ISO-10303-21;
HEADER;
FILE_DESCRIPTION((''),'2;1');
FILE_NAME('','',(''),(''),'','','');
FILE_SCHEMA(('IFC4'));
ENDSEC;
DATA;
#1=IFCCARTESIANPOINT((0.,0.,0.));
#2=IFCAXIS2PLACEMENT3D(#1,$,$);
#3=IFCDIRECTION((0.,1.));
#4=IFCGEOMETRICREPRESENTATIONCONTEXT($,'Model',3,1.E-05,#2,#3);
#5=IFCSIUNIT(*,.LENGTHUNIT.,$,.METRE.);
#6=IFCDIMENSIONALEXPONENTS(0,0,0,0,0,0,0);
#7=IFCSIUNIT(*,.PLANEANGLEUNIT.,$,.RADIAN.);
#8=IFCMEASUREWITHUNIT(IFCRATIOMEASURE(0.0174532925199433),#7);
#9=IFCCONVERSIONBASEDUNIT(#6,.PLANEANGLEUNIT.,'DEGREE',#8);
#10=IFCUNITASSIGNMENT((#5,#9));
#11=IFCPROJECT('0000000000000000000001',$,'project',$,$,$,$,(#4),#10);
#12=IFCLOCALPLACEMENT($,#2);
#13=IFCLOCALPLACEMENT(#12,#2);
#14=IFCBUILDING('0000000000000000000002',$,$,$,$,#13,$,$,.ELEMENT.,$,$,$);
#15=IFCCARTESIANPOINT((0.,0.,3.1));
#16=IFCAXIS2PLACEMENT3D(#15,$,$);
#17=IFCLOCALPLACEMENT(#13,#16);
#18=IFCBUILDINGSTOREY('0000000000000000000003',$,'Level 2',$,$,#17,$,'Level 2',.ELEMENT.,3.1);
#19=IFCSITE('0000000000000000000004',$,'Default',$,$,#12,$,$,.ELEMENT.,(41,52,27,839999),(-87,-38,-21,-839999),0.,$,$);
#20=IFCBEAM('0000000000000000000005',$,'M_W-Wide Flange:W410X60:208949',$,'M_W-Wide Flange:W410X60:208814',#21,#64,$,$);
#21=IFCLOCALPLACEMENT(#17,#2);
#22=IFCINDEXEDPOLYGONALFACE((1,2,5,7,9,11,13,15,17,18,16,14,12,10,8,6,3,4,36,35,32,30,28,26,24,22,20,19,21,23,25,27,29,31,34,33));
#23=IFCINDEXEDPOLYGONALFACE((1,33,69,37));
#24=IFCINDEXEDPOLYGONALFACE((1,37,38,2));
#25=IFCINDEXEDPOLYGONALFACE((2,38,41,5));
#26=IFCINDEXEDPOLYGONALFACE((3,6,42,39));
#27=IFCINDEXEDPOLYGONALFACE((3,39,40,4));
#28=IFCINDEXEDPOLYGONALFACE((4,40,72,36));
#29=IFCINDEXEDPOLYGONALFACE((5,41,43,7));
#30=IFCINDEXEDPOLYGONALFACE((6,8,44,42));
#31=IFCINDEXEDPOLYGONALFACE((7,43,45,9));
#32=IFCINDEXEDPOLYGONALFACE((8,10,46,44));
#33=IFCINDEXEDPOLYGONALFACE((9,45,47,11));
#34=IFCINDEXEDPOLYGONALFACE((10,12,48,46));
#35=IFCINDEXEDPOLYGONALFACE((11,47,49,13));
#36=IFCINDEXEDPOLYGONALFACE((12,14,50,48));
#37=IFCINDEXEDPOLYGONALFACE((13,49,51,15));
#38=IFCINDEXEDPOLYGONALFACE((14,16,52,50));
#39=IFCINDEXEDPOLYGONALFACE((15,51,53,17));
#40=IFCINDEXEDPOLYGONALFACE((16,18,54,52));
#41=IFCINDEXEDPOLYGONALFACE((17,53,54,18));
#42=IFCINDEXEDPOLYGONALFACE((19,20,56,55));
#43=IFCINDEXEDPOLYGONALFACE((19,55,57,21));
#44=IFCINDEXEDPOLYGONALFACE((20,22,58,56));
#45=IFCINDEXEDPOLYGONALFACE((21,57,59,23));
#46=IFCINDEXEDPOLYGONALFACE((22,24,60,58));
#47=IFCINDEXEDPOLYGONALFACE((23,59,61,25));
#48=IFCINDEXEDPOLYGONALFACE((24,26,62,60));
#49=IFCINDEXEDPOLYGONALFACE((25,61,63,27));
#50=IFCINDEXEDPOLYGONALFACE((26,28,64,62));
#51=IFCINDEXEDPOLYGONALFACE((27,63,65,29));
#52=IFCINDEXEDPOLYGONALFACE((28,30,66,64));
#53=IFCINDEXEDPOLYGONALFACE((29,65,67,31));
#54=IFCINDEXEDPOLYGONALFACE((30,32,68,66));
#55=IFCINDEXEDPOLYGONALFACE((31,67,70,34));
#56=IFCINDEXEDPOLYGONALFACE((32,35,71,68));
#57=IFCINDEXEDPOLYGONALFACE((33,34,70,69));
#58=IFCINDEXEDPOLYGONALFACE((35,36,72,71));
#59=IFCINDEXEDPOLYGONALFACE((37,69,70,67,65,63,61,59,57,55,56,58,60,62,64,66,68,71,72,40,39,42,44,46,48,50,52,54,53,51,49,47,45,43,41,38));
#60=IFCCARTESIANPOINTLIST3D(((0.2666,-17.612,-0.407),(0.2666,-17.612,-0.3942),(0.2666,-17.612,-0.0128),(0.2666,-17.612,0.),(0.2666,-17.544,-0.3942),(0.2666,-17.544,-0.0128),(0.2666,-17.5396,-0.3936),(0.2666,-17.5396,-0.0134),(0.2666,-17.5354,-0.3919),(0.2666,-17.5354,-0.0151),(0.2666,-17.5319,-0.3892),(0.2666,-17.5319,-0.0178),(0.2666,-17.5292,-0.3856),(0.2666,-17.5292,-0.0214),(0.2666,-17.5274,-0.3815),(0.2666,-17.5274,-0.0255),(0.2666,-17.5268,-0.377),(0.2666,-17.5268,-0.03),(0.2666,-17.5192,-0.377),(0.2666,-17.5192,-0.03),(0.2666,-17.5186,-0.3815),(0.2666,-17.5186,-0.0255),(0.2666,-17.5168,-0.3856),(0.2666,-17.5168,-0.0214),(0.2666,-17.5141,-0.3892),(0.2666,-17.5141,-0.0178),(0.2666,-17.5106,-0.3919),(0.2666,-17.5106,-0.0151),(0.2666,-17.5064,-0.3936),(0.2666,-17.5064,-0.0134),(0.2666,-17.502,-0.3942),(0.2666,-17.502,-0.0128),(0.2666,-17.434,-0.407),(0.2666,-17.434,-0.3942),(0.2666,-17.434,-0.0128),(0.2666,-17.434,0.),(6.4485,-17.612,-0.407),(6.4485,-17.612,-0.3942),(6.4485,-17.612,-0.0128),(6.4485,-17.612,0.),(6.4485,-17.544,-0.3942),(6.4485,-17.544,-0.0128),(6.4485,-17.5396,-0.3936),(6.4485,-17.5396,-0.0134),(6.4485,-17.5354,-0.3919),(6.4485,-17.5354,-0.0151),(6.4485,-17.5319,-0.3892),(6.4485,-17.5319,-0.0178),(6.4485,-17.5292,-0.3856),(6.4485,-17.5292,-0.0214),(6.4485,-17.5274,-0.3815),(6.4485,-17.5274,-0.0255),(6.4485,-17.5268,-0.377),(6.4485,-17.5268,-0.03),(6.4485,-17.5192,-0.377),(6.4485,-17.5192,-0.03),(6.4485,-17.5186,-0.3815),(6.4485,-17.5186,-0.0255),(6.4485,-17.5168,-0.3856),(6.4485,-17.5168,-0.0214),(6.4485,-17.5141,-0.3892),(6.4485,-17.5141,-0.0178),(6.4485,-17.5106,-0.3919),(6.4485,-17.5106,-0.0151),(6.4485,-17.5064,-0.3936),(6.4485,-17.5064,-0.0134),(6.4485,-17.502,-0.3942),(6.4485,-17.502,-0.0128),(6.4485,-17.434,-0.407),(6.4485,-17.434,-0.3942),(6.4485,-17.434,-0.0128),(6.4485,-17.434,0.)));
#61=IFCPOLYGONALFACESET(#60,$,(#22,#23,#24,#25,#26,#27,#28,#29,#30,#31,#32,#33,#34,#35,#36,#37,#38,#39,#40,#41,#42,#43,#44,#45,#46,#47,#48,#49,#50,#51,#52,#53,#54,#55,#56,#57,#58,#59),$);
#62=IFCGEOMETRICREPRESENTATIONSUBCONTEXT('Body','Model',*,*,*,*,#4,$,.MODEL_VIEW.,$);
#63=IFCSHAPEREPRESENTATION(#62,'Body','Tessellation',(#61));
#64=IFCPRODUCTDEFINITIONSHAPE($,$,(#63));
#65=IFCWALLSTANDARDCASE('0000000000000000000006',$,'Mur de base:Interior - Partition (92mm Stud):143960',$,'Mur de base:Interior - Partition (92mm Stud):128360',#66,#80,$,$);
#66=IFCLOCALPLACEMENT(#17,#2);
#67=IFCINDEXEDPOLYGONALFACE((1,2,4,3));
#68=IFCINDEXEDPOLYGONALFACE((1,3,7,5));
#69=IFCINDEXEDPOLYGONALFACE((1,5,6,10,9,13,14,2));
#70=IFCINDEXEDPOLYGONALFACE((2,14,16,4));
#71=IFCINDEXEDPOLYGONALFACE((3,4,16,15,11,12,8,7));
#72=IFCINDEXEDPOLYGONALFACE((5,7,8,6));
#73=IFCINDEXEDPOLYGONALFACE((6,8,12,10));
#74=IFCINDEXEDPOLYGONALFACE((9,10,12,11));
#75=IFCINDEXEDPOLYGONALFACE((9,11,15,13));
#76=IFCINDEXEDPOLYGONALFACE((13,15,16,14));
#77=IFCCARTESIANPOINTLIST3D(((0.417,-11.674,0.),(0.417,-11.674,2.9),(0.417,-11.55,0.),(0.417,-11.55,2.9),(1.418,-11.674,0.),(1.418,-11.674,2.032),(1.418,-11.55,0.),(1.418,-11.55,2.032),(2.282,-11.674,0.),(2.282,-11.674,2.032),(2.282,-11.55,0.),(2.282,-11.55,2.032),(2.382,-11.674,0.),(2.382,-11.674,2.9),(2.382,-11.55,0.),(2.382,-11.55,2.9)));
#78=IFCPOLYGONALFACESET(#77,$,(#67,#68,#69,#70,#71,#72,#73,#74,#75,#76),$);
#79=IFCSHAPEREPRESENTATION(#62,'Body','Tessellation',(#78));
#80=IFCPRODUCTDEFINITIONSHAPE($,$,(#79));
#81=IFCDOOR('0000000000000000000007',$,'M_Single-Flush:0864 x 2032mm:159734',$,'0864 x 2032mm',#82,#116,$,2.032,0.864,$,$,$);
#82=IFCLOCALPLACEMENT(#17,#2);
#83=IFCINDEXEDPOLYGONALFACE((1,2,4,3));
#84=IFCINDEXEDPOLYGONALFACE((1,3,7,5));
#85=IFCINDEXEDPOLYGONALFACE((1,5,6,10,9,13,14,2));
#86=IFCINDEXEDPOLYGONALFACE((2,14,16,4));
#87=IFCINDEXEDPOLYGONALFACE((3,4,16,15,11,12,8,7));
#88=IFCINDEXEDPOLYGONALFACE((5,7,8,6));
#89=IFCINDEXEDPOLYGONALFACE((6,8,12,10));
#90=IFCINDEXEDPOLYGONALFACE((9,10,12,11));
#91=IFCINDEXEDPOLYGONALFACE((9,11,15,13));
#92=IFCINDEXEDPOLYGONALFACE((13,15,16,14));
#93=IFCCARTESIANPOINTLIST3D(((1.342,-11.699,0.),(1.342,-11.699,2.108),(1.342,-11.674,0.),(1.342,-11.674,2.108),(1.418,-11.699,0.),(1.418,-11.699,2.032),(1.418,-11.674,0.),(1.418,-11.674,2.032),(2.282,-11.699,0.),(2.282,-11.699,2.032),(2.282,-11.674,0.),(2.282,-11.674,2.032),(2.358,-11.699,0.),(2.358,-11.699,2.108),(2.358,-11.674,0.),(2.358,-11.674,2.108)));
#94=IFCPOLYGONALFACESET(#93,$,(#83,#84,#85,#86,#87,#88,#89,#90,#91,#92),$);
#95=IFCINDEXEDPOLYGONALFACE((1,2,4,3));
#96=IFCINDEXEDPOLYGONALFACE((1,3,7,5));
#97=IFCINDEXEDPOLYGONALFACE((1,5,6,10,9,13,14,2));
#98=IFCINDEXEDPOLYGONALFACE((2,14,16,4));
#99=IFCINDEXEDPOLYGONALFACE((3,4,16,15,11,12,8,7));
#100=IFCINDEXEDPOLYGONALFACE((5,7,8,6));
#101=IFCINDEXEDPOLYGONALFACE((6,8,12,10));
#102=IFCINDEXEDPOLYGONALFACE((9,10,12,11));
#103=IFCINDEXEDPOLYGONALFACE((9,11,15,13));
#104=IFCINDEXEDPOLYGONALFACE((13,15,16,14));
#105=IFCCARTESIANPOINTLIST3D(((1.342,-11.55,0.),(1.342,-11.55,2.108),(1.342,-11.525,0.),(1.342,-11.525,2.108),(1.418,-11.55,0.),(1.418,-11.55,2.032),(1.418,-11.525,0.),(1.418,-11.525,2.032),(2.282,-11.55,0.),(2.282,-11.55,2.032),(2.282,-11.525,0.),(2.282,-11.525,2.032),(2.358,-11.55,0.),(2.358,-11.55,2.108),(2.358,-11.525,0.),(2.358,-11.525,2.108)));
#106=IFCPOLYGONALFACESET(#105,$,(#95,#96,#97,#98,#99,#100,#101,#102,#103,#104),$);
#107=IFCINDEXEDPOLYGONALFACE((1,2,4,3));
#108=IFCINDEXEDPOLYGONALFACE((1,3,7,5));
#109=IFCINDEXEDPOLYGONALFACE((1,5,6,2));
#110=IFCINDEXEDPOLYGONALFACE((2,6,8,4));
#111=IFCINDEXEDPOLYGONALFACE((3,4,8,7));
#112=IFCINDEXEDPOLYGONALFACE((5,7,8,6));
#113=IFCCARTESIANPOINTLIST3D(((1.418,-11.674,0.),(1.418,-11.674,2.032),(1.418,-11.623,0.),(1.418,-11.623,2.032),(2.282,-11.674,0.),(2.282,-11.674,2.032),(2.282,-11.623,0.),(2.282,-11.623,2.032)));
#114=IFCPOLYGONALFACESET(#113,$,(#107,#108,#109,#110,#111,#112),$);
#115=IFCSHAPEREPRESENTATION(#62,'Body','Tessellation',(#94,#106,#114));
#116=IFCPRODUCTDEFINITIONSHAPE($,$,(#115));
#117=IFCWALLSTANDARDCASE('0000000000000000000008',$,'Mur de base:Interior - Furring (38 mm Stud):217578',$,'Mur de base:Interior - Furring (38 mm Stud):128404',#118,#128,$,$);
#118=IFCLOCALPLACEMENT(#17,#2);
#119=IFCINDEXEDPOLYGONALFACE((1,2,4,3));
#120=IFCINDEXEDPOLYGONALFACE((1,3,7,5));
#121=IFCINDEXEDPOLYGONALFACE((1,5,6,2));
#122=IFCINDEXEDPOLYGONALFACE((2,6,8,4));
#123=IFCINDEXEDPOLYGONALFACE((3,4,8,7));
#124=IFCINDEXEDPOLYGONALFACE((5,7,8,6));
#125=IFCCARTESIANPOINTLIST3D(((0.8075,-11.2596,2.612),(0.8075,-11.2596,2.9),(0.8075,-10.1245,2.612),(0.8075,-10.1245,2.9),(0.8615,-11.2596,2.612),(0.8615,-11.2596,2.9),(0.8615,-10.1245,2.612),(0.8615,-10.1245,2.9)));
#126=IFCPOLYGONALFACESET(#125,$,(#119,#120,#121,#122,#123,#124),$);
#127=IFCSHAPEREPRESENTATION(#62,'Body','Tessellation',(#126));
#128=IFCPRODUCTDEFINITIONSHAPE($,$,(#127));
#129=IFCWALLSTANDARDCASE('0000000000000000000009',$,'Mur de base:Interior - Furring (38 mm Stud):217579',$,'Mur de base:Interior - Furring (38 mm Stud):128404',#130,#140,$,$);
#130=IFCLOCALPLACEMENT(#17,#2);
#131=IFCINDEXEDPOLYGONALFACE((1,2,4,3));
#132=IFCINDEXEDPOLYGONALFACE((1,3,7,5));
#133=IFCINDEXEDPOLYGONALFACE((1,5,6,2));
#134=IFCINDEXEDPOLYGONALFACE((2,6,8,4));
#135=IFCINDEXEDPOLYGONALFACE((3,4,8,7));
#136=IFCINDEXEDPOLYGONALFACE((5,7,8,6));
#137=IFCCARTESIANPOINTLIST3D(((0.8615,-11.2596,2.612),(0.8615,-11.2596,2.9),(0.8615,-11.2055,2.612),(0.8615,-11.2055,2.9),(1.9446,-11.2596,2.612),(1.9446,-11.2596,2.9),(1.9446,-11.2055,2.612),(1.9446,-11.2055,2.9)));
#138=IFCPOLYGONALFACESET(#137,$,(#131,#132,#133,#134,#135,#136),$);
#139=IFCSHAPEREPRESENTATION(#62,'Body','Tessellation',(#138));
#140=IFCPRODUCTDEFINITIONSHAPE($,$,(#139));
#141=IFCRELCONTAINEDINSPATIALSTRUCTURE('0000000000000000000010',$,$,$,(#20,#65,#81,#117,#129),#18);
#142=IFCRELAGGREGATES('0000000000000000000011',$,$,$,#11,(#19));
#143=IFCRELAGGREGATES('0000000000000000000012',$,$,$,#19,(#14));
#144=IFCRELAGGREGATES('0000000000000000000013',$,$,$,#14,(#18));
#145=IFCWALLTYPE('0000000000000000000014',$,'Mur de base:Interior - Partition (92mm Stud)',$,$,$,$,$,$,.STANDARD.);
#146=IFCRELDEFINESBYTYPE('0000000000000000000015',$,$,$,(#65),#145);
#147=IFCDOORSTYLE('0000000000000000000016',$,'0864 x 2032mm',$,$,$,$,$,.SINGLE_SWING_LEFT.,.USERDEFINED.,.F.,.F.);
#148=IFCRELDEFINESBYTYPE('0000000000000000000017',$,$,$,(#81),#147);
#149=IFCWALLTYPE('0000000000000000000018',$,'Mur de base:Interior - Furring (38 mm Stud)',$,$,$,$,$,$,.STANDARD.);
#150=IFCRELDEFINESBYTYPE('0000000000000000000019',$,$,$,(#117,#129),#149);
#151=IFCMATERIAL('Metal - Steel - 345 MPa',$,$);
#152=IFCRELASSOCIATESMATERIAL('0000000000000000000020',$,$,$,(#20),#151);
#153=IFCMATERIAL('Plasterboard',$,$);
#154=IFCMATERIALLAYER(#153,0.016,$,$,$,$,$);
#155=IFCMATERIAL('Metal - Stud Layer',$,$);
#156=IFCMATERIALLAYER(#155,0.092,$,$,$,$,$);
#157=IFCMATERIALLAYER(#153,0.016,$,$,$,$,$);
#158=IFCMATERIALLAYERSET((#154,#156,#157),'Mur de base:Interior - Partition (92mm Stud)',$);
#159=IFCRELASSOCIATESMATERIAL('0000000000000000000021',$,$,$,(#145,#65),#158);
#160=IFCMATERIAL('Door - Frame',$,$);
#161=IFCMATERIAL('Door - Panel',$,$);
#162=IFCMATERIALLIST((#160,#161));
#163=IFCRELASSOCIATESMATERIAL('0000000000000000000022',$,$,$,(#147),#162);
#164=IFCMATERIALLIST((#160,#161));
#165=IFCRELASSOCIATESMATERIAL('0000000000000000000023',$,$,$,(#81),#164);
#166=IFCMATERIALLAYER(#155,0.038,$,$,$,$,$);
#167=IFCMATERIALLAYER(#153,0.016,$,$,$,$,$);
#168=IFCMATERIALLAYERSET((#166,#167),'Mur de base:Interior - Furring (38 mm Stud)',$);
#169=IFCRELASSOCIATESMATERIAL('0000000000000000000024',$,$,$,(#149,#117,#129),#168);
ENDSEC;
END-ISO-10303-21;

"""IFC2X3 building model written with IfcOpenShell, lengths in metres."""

from ifc_helpers import new_model, entity, si_unit, converted_unit, direction, frame, frame_2d, origin, place, context, subcontext, project, spatial, polyline, rectangle, i_section, outline, extrude, source, transform, mapped, material, material_list, layer, layer_set, layer_usage, type_object, type_shapes, element, fill, save


model = new_model("IFC2X3")

# Units and contexts
model_context = context("Model", 3, precision=1e-05, world=origin(), true_north=direction((0.0, 1.0)))
body_context = subcontext(model_context, "Body", "Model", "MODEL_VIEW")
ifc_project = project(units=[si_unit("LENGTHUNIT", "METRE"), converted_unit("PLANEANGLEUNIT", "DEGREE", entity("IfcRatioMeasure", 0.0174532925199433), si_unit("PLANEANGLEUNIT", "RADIAN"), dimensions=[0, 0, 0, 0, 0, 0, 0])], contexts=[model_context])

# Site, building, storey
site_placement = place(None, origin())
site = spatial("IfcSite", under=ifc_project, at=site_placement, Name="Default", CompositionType="ELEMENT", RefLatitude=(41, 52, 27, 839999), RefLongitude=(-87, -38, -21, -839999), RefElevation=0.0)
building_placement = place(site_placement, origin())
building = spatial("IfcBuilding", under=site, at=building_placement, CompositionType="ELEMENT")
storey_placement = place(building_placement, frame((0.0, 0.0, 3.1)))
storey = spatial("IfcBuildingStorey", under=building, at=storey_placement, Name="Level 2", LongName="Level 2", CompositionType="ELEMENT", Elevation=3.1)

# Beam
ifc_material_1 = material(Name="Metal - Steel - 345 MPa")
beam_placement = place(storey_placement, frame((0.2666, -17.523, 0.0)))
element("IfcBeam", 1, at=beam_placement, inside=storey, material=ifc_material_1, Name="M_W-Wide Flange:W410X60:208949", ObjectType="M_W-Wide Flange:W410X60:208814", context=body_context, shape_type="SweptSolid", body=[
    extrude(i_section(OverallWidth=0.178, OverallDepth=0.407, WebThickness=0.0077, FlangeThickness=0.0128, FilletRadius=0.0172, at=frame_2d((0.0, 0.0), x_axis=(0.0, 1.0))), frame((0.0, 0.0, -0.2035), z_axis=(1.0, 0.0, 0.0), x_axis=(0.0, 0.0, -1.0)), (0.0, 0.0, 1.0), 6.1819),
])

# Shared definitions
ifc_material_2 = material(Name="Metal - Stud Layer")
ifc_material_3 = material(Name="Plasterboard")

# Wall, opening, door
ifc_layer_1 = layer(ifc_material_3, 0.016)
ifc_layer_2 = layer(ifc_material_2, 0.092)
ifc_layer_3 = layer(ifc_material_3, 0.016)
ifc_layer_set_1 = layer_set([ifc_layer_1, ifc_layer_2, ifc_layer_3], Name="Mur de base:Interior - Partition (92mm Stud)")
ifc_layer_usage_1 = layer_usage(ifc_layer_set_1, "AXIS2", "NEGATIVE", 0.062)
wall_type_1 = type_object("IfcWallType", Name="Mur de base:Interior - Partition (92mm Stud)", PredefinedType="STANDARD", material=ifc_layer_set_1)
wall_1_placement = place(storey_placement, frame((2.382, -11.612, 0.0), z_axis=(0.0, 0.0, 1.0), x_axis=(-1.0, 0.0, 0.0)))
wall_1 = element("IfcWallStandardCase", 2, at=wall_1_placement, inside=storey, type_object=wall_type_1, material=ifc_layer_usage_1, Name="Mur de base:Interior - Partition (92mm Stud):143960", ObjectType="Mur de base:Interior - Partition (92mm Stud):128360", context=body_context, shape_type="SweptSolid", body=[
    extrude(rectangle(XDim=1.965, YDim=0.124, at=frame_2d((0.9825, 0.0), x_axis=(-1.0, 0.0))), origin(), (0.0, 0.0, 1.0), 2.9),
])
opening_1_placement = place(wall_1_placement, frame((0.1, -0.062, 0.0)))
opening_1 = element("IfcOpeningElement", 3, at=opening_1_placement, cuts=wall_1, ObjectType="Opening", context=body_context, shape_type="SweptSolid", body=[
    extrude(rectangle(XDim=0.864, YDim=2.032, at=frame_2d((1.016, 0.432), x_axis=(0.0, -1.0))), frame((0.0, 0.0, 0.0), z_axis=(0.0, 1.0, 0.0), x_axis=(0.0, 0.0, 1.0)), (0.0, 0.0, 1.0), 0.124),
])
ifc_material_4 = material(Name="Door - Frame")
ifc_material_5 = material(Name="Door - Panel")
ifc_material_list_1 = material_list([ifc_material_4, ifc_material_5])
ifc_material_list_2 = material_list([ifc_material_4, ifc_material_5])
door_style = type_object("IfcDoorStyle", Name="0864 x 2032mm", ConstructionType="USERDEFINED", OperationType="SINGLE_SWING_LEFT", ParameterTakesPrecedence=False, Sizeable=False, material=ifc_material_list_2)
shared_shape_1 = source(origin(), body_context, "Body", "SweptSolid", [
    extrude(outline(polyline([(-0.508, -1.073), (0.508, -1.073), (0.508, 1.035), (0.432, 1.035), (0.432, -0.997), (-0.432, -0.997), (-0.432, 1.035), (-0.508, 1.035), (-0.508, -1.073)])), frame((0.432, 0.149, 1.035), z_axis=(0.0, -1.0, 0.0), x_axis=(-1.0, 0.0, 0.0)), (0.0, 0.0, 1.0), 0.025),
    extrude(outline(polyline([(-1.073, -0.508), (1.035, -0.508), (1.035, -0.432), (-0.997, -0.432), (-0.997, 0.432), (1.035, 0.432), (1.035, 0.508), (-1.073, 0.508), (-1.073, -0.508)])), frame((0.432, 0.0, 1.035), z_axis=(0.0, -1.0, 0.0), x_axis=(0.0, 0.0, -1.0)), (0.0, 0.0, 1.0), 0.025),
    extrude(rectangle(XDim=0.864, YDim=0.051, at=frame_2d((0.0, 0.0), x_axis=(1.0, 0.0))), frame((0.432, 0.0985, 0.0)), (0.0, 0.0, 1.0), 2.032),
])
type_shapes(door_style, [shared_shape_1])
door_placement = place(opening_1_placement, origin())
door = element("IfcDoor", 4, at=door_placement, inside=storey, type_object=door_style, material=ifc_material_list_1, Name="M_Single-Flush:0864 x 2032mm:159734", ObjectType="0864 x 2032mm", OverallHeight=2.032, OverallWidth=0.864, context=body_context, shape_type="MappedRepresentation", body=[
    mapped(shared_shape_1, transform((0.0, 0.0, 0.0), scale=1.0)),
])
fill(opening_1, door)

# Walls
ifc_layer_4 = layer(ifc_material_2, 0.038)
ifc_layer_5 = layer(ifc_material_3, 0.016)
ifc_layer_set_2 = layer_set([ifc_layer_4, ifc_layer_5], Name="Mur de base:Interior - Furring (38 mm Stud)")
ifc_layer_usage_2 = layer_usage(ifc_layer_set_2, "AXIS2", "NEGATIVE", 0.027)
wall_type_2 = type_object("IfcWallType", Name="Mur de base:Interior - Furring (38 mm Stud)", PredefinedType="STANDARD", material=ifc_layer_set_2)
wall_2_placement = place(storey_placement, frame((0.8345, -11.2596, 2.612), z_axis=(0.0, 0.0, 1.0), x_axis=(0.0, 1.0, 0.0)))
element("IfcWallStandardCase", 5, at=wall_2_placement, inside=storey, type_object=wall_type_2, material=ifc_layer_usage_2, Name="Mur de base:Interior - Furring (38 mm Stud):217578", ObjectType="Mur de base:Interior - Furring (38 mm Stud):128404", context=body_context, shape_type="SweptSolid", body=[
    extrude(rectangle(XDim=1.1351, YDim=0.054, at=frame_2d((0.5675, 0.0), x_axis=(-1.0, 0.0))), origin(), (0.0, 0.0, 1.0), 0.288),
])
ifc_layer_usage_3 = layer_usage(ifc_layer_set_2, "AXIS2", "NEGATIVE", 0.027)
wall_3_placement = place(storey_placement, frame((1.9446, -11.2325, 2.612), z_axis=(0.0, 0.0, 1.0), x_axis=(-1.0, 0.0, 0.0)))
element("IfcWallStandardCase", 6, at=wall_3_placement, inside=storey, type_object=wall_type_2, material=ifc_layer_usage_3, Name="Mur de base:Interior - Furring (38 mm Stud):217579", ObjectType="Mur de base:Interior - Furring (38 mm Stud):128404", context=body_context, shape_type="SweptSolid", body=[
    extrude(rectangle(XDim=1.0831, YDim=0.054, at=frame_2d((0.5415, 0.0), x_axis=(-1.0, 0.0))), origin(), (0.0, 0.0, 1.0), 0.288),
])

save(model, "model.ifc")
